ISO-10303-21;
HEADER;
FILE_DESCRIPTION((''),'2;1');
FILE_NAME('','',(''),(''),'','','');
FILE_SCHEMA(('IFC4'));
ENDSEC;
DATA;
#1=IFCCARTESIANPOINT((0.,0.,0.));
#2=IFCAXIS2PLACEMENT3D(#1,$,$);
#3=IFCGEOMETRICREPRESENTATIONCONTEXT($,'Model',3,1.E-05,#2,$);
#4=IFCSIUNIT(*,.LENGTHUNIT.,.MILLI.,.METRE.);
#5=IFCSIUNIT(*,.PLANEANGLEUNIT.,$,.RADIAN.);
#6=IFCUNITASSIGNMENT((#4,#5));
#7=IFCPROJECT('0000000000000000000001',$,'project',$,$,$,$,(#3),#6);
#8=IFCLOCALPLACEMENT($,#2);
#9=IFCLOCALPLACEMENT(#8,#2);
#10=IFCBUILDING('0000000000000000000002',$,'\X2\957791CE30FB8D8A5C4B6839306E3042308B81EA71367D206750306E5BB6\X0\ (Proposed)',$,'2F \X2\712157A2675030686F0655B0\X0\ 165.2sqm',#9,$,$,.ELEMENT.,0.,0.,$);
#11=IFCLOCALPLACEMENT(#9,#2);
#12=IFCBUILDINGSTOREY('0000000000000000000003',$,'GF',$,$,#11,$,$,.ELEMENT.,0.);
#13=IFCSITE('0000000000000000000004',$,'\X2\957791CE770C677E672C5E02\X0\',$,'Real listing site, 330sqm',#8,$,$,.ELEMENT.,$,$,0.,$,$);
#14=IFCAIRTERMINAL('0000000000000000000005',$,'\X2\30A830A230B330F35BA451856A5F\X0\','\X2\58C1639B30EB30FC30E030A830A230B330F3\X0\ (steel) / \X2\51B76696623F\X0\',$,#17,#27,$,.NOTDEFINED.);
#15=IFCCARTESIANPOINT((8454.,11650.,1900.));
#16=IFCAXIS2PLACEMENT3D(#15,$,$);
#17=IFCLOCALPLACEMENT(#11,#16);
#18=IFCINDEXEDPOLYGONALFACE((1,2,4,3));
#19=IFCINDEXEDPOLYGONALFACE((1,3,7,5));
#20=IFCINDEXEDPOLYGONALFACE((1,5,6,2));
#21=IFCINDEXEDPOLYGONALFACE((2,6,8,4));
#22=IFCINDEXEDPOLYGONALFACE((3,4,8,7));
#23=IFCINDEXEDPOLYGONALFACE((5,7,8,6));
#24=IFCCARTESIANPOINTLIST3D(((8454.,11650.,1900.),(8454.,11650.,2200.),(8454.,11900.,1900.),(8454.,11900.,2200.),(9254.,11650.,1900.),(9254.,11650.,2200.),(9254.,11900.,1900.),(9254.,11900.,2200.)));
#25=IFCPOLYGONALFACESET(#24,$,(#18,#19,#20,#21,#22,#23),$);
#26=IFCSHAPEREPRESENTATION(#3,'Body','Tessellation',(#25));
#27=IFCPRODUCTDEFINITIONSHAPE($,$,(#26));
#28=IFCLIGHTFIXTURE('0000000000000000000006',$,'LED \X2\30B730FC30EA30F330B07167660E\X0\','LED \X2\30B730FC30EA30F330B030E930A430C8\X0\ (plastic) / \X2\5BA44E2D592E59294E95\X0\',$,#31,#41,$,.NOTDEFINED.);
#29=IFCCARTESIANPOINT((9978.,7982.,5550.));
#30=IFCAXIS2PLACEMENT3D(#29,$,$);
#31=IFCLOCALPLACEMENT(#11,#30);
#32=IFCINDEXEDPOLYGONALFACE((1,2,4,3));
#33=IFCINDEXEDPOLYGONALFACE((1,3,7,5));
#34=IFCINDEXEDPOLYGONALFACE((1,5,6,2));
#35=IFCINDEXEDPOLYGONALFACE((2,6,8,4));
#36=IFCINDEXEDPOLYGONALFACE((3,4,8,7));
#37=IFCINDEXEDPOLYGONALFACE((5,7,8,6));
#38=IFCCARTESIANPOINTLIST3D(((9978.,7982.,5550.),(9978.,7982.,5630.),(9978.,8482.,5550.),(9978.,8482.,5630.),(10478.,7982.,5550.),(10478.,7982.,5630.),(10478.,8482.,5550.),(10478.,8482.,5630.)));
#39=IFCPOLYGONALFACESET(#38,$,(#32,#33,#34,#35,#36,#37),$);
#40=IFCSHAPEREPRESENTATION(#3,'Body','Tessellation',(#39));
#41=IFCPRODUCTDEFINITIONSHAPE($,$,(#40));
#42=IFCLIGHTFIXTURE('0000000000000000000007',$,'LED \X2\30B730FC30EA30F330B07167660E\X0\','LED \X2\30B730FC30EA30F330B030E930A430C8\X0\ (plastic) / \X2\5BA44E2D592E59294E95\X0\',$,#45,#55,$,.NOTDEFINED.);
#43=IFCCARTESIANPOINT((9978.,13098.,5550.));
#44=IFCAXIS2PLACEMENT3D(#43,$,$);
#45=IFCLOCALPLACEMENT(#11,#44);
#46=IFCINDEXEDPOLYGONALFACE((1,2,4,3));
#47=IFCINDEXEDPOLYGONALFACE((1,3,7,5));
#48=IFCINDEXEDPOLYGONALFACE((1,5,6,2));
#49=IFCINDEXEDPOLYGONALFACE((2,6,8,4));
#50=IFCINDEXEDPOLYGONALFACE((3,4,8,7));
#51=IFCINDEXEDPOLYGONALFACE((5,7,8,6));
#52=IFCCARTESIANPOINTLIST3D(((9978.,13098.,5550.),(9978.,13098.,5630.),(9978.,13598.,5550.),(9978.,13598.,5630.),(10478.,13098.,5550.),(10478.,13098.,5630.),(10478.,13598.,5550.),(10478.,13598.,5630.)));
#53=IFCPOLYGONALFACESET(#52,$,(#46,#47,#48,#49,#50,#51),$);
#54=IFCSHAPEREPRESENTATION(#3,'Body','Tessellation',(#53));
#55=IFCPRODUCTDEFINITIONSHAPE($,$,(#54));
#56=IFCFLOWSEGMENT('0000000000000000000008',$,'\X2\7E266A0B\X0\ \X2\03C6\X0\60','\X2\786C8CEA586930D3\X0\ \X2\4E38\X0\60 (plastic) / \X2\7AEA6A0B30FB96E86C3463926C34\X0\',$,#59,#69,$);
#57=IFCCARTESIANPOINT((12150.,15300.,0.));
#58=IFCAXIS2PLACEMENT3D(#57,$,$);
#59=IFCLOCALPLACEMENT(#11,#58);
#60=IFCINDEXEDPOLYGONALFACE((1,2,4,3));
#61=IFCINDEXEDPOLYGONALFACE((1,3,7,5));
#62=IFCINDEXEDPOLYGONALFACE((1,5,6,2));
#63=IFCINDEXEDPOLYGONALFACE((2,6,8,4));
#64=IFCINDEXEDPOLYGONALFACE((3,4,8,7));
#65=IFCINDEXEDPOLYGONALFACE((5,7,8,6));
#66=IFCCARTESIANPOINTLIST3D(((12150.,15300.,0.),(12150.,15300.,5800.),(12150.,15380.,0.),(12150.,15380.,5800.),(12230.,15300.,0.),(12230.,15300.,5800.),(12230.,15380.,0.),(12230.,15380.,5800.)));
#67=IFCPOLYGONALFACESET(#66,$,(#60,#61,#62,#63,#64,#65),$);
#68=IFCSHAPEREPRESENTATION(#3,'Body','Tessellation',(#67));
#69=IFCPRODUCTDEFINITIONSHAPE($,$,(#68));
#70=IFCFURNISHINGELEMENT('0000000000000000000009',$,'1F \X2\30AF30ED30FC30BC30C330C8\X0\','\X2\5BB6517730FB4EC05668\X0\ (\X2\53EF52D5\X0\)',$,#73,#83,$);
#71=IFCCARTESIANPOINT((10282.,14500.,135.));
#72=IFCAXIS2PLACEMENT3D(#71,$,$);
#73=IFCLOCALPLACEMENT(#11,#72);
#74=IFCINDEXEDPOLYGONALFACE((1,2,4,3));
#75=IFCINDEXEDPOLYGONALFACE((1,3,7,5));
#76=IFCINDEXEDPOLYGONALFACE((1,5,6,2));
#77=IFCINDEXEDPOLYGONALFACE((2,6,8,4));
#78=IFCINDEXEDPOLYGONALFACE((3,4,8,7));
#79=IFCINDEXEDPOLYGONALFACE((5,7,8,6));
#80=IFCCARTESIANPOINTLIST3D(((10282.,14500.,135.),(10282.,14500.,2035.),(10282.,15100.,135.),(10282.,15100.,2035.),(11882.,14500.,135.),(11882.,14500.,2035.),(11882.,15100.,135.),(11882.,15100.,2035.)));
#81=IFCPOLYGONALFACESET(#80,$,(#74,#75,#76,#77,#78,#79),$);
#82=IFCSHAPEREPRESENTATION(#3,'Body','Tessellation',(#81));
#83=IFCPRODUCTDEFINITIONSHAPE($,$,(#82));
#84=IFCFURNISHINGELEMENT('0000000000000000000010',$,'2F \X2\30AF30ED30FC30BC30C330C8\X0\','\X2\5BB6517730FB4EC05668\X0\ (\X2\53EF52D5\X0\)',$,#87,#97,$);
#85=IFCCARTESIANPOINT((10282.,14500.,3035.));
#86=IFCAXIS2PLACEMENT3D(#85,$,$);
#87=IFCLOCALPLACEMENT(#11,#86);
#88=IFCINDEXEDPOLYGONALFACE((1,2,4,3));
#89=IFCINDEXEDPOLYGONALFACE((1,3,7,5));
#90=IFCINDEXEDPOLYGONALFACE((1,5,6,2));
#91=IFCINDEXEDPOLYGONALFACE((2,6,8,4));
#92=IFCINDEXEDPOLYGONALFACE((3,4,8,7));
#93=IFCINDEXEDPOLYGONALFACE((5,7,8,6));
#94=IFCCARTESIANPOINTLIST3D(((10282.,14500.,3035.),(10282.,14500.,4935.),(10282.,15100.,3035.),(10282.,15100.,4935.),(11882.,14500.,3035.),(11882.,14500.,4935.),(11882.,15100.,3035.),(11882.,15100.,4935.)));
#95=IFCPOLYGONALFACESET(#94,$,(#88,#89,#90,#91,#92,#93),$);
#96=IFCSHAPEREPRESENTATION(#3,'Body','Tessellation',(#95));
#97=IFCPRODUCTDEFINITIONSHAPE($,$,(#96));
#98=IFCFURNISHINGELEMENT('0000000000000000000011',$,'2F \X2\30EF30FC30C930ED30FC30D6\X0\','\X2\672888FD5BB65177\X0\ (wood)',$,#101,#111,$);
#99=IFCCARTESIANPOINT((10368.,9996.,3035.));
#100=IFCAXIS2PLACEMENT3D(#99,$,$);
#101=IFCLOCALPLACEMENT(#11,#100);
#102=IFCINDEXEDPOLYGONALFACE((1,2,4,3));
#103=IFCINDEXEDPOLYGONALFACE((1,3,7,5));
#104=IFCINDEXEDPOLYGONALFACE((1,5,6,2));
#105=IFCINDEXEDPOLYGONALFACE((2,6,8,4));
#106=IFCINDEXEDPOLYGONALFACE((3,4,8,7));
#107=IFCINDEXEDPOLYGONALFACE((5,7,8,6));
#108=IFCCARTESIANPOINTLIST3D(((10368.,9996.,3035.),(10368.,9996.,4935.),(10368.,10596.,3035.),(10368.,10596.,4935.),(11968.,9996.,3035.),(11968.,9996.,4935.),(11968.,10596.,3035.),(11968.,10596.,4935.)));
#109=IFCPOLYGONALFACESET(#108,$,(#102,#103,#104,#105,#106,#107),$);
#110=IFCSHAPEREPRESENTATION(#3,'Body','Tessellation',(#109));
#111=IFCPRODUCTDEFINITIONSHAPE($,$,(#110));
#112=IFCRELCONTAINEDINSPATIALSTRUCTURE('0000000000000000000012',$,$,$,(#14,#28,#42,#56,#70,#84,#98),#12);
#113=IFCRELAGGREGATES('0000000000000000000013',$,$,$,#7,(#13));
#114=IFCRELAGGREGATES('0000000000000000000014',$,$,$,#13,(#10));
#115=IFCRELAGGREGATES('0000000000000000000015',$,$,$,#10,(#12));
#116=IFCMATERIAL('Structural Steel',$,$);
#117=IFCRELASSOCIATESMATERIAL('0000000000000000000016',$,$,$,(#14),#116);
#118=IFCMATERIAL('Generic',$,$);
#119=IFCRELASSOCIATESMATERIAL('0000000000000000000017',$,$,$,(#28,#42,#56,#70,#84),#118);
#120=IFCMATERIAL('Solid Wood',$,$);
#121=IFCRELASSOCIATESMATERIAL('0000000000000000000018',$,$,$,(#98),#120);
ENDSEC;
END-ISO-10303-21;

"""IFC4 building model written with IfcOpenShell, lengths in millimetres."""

from ifc_helpers import new_model, si_unit, frame, frame_2d, origin, place, context, project, spatial, rectangle, extrude, material, element, save


model = new_model("IFC4")

# Units and contexts
model_context = context("Model", 3, precision=1e-05, world=origin())
ifc_project = project(units=[si_unit("LENGTHUNIT", "METRE", prefix="MILLI"), si_unit("PLANEANGLEUNIT", "RADIAN")], contexts=[model_context])

# Site, building, storey
site_placement = place(None, origin())
site = spatial("IfcSite", under=ifc_project, at=site_placement, Name="長野県松本市", ObjectType="Real listing site, 330sqm", CompositionType="ELEMENT", RefElevation=0.0)
building_placement = place(site_placement, origin())
building = spatial("IfcBuilding", under=site, at=building_placement, Name="長野・越屋根のある自然素材の家 (Proposed)", ObjectType="2F 無垢材と漆喰 165.2sqm", CompositionType="ELEMENT", ElevationOfRefHeight=0.0, ElevationOfTerrain=0.0)
storey_placement = place(building_placement, origin())
storey = spatial("IfcBuildingStorey", under=building, at=storey_placement, Name="GF", CompositionType="ELEMENT", Elevation=0.0)

# Shared definitions
ifc_material_1 = material(Name="Solid Wood")

# Shared definitions
ifc_material_2 = material(Name="Generic")

# Shared definitions
ifc_material_3 = material(Name="Structural Steel")

# Air terminal
air_terminal_placement = place(storey_placement, frame((8454.0, 11650.0, 1900.0)))
element("IfcAirTerminal", 1, at=air_terminal_placement, inside=storey, material=ifc_material_3, Name="エアコン室内機", Description="壁掛ルームエアコン (steel) / 冷暖房", PredefinedType="NOTDEFINED", context=model_context, shape_type="SweptSolid", body=[
    extrude(rectangle(XDim=800.0, YDim=250.0, at=frame_2d((400.0, 125.0))), frame((8454.0, 11650.0, 1900.0)), (0.0, 0.0, 1.0), 300.0),
])

# Light fixtures
light_fixture_1_placement = place(storey_placement, frame((9978.0, 7982.0, 5550.0)))
element("IfcLightFixture", 2, at=light_fixture_1_placement, inside=storey, material=ifc_material_2, Name="LED シーリング照明", Description="LED シーリングライト (plastic) / 室中央天井", PredefinedType="NOTDEFINED", context=model_context, shape_type="SweptSolid", body=[
    extrude(rectangle(XDim=500.0, YDim=500.0, at=frame_2d((250.0, 250.0))), frame((9978.0, 7982.0, 5550.0)), (0.0, 0.0, 1.0), 80.0),
])
light_fixture_2_placement = place(storey_placement, frame((9978.0, 13098.0, 5550.0)))
element("IfcLightFixture", 3, at=light_fixture_2_placement, inside=storey, material=ifc_material_2, Name="LED シーリング照明", Description="LED シーリングライト (plastic) / 室中央天井", PredefinedType="NOTDEFINED", context=model_context, shape_type="SweptSolid", body=[
    extrude(rectangle(XDim=500.0, YDim=500.0, at=frame_2d((250.0, 250.0))), frame((9978.0, 13098.0, 5550.0)), (0.0, 0.0, 1.0), 80.0),
])

# Flow segment
flow_segment_placement = place(storey_placement, frame((12150.0, 15300.0, 0.0)))
element("IfcFlowSegment", 4, at=flow_segment_placement, inside=storey, material=ifc_material_2, Name="縦樋 φ60", Description="硬質塩ビ 丸60 (plastic) / 竪樋・雨水排水", context=model_context, shape_type="SweptSolid", body=[
    extrude(rectangle(XDim=80.0, YDim=80.0, at=frame_2d((40.0, 40.0))), frame((12150.0, 15300.0, 0.0)), (0.0, 0.0, 1.0), 5800.0),
])

# Furnishing elements
furnishing_1_placement = place(storey_placement, frame((10282.0, 14500.0, 135.0)))
element("IfcFurnishingElement", 5, at=furnishing_1_placement, inside=storey, material=ifc_material_2, Name="1F クローゼット", Description="家具・什器 (可動)", context=model_context, shape_type="SweptSolid", body=[
    extrude(rectangle(XDim=1600.0, YDim=600.0, at=frame_2d((800.0, 300.0))), frame((10282.0, 14500.0, 135.0)), (0.0, 0.0, 1.0), 1900.0),
])
furnishing_2_placement = place(storey_placement, frame((10282.0, 14500.0, 3035.0)))
element("IfcFurnishingElement", 6, at=furnishing_2_placement, inside=storey, material=ifc_material_2, Name="2F クローゼット", Description="家具・什器 (可動)", context=model_context, shape_type="SweptSolid", body=[
    extrude(rectangle(XDim=1600.0, YDim=600.0, at=frame_2d((800.0, 300.0))), frame((10282.0, 14500.0, 3035.0)), (0.0, 0.0, 1.0), 1900.0),
])
furnishing_3_placement = place(storey_placement, frame((10368.0, 9996.0, 3035.0)))
element("IfcFurnishingElement", 7, at=furnishing_3_placement, inside=storey, material=ifc_material_1, Name="2F ワードローブ", Description="木製家具 (wood)", context=model_context, shape_type="SweptSolid", body=[
    extrude(rectangle(XDim=1600.0, YDim=600.0, at=frame_2d((800.0, 300.0))), frame((10368.0, 9996.0, 3035.0)), (0.0, 0.0, 1.0), 1900.0),
])

save(model, "model.ifc")
